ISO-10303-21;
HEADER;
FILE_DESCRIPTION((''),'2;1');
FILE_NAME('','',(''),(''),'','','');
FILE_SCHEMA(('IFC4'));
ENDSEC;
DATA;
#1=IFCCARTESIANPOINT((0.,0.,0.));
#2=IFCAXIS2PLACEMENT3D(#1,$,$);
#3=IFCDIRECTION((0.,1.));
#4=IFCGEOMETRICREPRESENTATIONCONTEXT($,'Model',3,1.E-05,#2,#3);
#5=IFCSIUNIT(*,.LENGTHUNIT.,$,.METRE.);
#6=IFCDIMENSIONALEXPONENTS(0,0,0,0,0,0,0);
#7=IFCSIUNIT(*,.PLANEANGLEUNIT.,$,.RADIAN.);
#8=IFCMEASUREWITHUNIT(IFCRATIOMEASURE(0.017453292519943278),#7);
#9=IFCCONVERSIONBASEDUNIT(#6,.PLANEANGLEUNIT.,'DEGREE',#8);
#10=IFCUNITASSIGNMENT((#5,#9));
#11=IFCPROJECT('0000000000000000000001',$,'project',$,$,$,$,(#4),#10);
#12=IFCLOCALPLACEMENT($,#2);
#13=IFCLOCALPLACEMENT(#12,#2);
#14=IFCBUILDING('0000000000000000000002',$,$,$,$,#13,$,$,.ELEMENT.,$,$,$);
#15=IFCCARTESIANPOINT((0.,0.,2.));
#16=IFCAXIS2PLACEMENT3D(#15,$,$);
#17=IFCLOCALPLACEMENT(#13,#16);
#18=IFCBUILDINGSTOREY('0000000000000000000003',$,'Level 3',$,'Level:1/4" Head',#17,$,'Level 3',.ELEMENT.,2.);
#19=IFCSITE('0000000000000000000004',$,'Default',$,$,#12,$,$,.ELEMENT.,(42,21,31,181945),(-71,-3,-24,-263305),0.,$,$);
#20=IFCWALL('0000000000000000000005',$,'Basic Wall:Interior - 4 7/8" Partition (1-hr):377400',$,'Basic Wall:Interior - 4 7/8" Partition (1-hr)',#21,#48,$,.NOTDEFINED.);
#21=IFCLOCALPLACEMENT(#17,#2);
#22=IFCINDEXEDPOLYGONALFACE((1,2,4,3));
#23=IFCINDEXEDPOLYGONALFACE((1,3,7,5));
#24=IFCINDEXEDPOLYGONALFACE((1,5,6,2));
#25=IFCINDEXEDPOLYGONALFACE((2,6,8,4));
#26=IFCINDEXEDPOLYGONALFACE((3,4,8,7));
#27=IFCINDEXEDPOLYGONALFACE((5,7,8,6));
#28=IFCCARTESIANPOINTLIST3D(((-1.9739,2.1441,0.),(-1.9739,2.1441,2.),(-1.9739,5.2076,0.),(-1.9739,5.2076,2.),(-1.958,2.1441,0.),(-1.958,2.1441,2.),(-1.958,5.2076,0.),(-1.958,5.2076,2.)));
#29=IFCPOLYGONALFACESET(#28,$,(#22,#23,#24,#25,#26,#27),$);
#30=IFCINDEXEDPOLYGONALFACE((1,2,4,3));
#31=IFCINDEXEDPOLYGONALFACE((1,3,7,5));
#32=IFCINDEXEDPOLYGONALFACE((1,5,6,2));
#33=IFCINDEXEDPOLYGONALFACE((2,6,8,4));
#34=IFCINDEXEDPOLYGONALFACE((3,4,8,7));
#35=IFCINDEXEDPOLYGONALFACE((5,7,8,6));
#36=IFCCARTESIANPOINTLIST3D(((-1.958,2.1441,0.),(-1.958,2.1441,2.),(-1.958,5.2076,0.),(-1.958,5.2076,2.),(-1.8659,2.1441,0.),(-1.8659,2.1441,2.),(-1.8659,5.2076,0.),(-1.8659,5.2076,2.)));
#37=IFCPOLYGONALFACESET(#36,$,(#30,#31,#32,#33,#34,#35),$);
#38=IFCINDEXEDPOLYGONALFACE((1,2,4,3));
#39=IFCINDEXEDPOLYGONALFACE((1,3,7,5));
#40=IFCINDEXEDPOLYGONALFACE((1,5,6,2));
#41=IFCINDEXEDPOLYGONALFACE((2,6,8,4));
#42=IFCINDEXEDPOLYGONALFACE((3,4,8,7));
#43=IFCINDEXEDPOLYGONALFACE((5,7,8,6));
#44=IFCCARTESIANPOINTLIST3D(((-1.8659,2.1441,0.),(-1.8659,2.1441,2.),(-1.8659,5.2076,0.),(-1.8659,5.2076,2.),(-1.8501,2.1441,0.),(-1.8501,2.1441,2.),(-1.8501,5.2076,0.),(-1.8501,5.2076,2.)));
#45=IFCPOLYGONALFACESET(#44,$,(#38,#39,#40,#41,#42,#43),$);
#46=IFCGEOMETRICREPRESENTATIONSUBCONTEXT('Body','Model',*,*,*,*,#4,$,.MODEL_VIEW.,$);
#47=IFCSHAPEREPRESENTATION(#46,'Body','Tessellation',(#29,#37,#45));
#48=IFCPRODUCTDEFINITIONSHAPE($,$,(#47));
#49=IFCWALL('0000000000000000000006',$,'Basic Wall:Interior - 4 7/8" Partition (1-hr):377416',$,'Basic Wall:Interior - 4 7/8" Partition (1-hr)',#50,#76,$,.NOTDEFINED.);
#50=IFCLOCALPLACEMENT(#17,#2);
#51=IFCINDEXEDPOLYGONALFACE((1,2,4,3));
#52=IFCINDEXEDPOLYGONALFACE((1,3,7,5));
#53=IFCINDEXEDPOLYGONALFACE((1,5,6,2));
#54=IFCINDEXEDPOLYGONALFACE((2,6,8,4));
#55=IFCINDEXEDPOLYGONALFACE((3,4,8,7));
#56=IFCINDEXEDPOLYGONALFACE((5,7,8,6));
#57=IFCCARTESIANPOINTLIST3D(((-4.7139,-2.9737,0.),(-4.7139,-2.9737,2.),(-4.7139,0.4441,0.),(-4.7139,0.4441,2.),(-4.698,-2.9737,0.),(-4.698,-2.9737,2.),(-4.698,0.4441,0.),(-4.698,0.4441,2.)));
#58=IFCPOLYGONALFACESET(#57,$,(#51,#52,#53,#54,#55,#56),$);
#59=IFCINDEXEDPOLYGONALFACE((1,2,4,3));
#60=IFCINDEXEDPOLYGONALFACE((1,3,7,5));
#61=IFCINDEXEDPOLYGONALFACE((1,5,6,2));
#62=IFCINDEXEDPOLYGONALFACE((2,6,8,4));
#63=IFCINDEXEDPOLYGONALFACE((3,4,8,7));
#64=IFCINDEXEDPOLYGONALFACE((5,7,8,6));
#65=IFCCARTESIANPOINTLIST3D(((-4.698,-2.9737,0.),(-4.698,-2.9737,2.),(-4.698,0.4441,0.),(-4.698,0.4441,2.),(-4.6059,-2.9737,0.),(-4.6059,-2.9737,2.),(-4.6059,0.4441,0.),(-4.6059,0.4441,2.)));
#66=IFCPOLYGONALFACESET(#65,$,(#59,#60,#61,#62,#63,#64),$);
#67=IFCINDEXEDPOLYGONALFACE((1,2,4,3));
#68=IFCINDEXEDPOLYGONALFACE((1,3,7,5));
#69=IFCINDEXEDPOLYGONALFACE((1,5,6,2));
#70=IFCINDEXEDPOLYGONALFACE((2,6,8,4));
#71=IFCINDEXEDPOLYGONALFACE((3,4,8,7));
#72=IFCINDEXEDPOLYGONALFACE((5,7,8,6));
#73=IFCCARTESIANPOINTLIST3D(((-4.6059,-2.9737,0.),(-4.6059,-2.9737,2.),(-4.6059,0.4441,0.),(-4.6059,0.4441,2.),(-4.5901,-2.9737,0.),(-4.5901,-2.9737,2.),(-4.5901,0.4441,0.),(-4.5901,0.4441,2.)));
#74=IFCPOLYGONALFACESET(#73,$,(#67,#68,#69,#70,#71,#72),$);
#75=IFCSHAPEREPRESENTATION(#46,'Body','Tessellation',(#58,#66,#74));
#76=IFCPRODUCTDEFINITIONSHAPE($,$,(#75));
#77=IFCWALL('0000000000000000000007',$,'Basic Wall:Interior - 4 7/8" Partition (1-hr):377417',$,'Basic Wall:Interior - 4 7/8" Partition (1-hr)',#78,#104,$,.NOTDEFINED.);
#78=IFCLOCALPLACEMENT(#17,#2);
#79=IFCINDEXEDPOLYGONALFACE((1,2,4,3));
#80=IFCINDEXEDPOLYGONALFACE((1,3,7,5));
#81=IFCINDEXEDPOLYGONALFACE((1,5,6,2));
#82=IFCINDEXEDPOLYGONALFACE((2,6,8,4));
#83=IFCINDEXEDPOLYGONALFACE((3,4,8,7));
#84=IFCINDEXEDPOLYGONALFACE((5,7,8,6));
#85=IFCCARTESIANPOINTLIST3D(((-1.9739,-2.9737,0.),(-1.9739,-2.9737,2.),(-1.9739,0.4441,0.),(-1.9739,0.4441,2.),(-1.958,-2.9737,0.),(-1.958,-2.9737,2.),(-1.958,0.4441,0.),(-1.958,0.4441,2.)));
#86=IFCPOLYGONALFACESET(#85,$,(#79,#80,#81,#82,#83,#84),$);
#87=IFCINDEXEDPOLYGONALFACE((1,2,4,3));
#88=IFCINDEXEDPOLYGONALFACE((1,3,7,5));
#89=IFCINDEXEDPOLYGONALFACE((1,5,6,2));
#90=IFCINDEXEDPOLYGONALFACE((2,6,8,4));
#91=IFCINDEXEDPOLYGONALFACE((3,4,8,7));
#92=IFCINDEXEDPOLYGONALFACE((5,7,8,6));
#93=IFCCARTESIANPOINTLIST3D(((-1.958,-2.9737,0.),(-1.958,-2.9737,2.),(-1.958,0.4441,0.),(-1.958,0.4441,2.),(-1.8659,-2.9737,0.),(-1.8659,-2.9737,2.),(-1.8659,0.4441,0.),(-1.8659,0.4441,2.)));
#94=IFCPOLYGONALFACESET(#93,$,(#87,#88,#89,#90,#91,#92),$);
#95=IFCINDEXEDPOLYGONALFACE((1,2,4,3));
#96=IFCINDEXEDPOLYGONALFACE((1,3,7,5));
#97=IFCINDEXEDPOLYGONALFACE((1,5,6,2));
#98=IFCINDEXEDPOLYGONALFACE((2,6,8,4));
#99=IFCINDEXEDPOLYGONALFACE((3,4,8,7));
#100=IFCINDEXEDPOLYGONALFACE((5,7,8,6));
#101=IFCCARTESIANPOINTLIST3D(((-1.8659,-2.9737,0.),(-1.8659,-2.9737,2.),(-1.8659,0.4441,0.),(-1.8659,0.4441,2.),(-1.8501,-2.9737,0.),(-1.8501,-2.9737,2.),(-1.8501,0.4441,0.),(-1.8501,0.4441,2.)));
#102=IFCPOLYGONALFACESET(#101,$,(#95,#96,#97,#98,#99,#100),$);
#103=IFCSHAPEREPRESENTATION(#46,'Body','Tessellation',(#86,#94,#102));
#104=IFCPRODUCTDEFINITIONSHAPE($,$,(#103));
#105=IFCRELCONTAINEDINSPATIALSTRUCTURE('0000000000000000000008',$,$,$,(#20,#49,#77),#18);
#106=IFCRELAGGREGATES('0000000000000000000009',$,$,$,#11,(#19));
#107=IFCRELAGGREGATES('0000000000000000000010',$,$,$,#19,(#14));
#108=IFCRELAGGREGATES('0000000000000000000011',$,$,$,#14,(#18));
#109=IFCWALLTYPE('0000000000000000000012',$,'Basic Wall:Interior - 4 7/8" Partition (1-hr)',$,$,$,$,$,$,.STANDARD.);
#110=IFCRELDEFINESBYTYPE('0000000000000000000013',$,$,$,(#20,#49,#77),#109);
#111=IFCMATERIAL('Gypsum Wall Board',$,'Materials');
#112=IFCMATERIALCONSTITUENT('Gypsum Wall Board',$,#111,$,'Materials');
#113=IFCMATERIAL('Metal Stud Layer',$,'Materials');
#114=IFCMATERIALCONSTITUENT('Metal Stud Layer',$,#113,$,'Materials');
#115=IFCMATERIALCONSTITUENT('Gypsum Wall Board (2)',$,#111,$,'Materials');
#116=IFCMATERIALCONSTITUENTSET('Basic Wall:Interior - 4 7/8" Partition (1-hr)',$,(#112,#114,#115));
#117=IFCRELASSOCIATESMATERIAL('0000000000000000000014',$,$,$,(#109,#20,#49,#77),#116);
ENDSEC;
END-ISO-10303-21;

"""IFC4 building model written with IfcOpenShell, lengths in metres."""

from ifc_helpers import new_model, entity, si_unit, converted_unit, direction, frame, origin, place, context, subcontext, project, spatial, indexed_curve, outline, extrude, material, constituent, constituent_set, type_object, element, save


model = new_model("IFC4")

# Units and contexts
model_context = context("Model", 3, precision=1e-05, world=origin(), true_north=direction((0.0, 1.0)))
body_context = subcontext(model_context, "Body", "Model", "MODEL_VIEW")
ifc_project = project(units=[si_unit("LENGTHUNIT", "METRE"), converted_unit("PLANEANGLEUNIT", "DEGREE", entity("IfcRatioMeasure", 0.017453292519943278), si_unit("PLANEANGLEUNIT", "RADIAN"), dimensions=[0, 0, 0, 0, 0, 0, 0])], contexts=[model_context])

# Site, building, storey
site_placement = place(None, origin())
site = spatial("IfcSite", under=ifc_project, at=site_placement, Name="Default", CompositionType="ELEMENT", RefLatitude=(42, 21, 31, 181945), RefLongitude=(-71, -3, -24, -263305), RefElevation=0.0)
building_placement = place(site_placement, origin())
building = spatial("IfcBuilding", under=site, at=building_placement, CompositionType="ELEMENT")
storey_placement = place(building_placement, frame((0.0, 0.0, 2.0)))
storey = spatial("IfcBuildingStorey", under=building, at=storey_placement, Name="Level 3", ObjectType="Level:1/4\" Head", LongName="Level 3", CompositionType="ELEMENT", Elevation=2.0)

# Walls
ifc_material_1 = material(Name="Gypsum Wall Board", Category="Materials")
ifc_constituent_1 = constituent(ifc_material_1, Name="Gypsum Wall Board", Category="Materials")
ifc_material_2 = material(Name="Metal Stud Layer", Category="Materials")
ifc_constituent_2 = constituent(ifc_material_2, Name="Metal Stud Layer", Category="Materials")
ifc_constituent_3 = constituent(ifc_material_1, Name="Gypsum Wall Board (2)", Category="Materials")
ifc_constituent_set = constituent_set(constituents=[ifc_constituent_1, ifc_constituent_2, ifc_constituent_3], Name="Basic Wall:Interior - 4 7/8\" Partition (1-hr)")
wall_type_1 = type_object("IfcWallType", Name="Basic Wall:Interior - 4 7/8\" Partition (1-hr)", PredefinedType="STANDARD", material=ifc_constituent_set)
wall_1_placement = place(storey_placement, frame((-1.912, 5.2076, 0.0), z_axis=(0.0, 0.0, 1.0), x_axis=(0.0, -1.0, 0.0)))
element("IfcWall", 1, at=wall_1_placement, inside=storey, type_object=wall_type_1, material=ifc_constituent_set, Name="Basic Wall:Interior - 4 7/8\" Partition (1-hr):377400", ObjectType="Basic Wall:Interior - 4 7/8\" Partition (1-hr)", PredefinedType="NOTDEFINED", context=body_context, shape_type="SweptSolid", body=[
    extrude(outline(indexed_curve([(-0.0079, -1.5318), (0.0079, -1.5318), (0.0079, 1.5318), (-0.0079, 1.5318), (-0.0079, -1.5318)], self_intersect=False)), frame((1.5318, -0.054, 0.0), z_axis=(0.0, 0.0, 1.0), x_axis=(0.0, 1.0, 0.0)), (0.0, 0.0, 1.0), 2.0),
    extrude(outline(indexed_curve([(-1.5318, -0.046), (1.5318, -0.046), (1.5318, 0.046), (-1.5318, 0.046), (-1.5318, -0.046)], self_intersect=False)), frame((1.5318, 0.0, 0.0)), (0.0, 0.0, 1.0), 2.0),
    extrude(outline(indexed_curve([(-0.0079, -1.5318), (0.0079, -1.5318), (0.0079, 1.5318), (-0.0079, 1.5318), (-0.0079, -1.5318)], self_intersect=False)), frame((1.5318, 0.054, 0.0), z_axis=(0.0, 0.0, 1.0), x_axis=(0.0, -1.0, 0.0)), (0.0, 0.0, 1.0), 2.0),
])
wall_2_placement = place(storey_placement, frame((-4.652, 0.4441, 0.0), z_axis=(0.0, 0.0, 1.0), x_axis=(0.0, -1.0, 0.0)))
element("IfcWall", 2, at=wall_2_placement, inside=storey, type_object=wall_type_1, material=ifc_constituent_set, Name="Basic Wall:Interior - 4 7/8\" Partition (1-hr):377416", ObjectType="Basic Wall:Interior - 4 7/8\" Partition (1-hr)", PredefinedType="NOTDEFINED", context=body_context, shape_type="SweptSolid", body=[
    extrude(outline(indexed_curve([(-0.0079, -1.7089), (0.0079, -1.7089), (0.0079, 1.7089), (-0.0079, 1.7089), (-0.0079, -1.7089)], self_intersect=False)), frame((1.7089, -0.054, 0.0), z_axis=(0.0, 0.0, 1.0), x_axis=(0.0, 1.0, 0.0)), (0.0, 0.0, 1.0), 2.0),
    extrude(outline(indexed_curve([(-1.7089, -0.046), (1.7089, -0.046), (1.7089, 0.046), (-1.7089, 0.046), (-1.7089, -0.046)], self_intersect=False)), frame((1.7089, 0.0, 0.0)), (0.0, 0.0, 1.0), 2.0),
    extrude(outline(indexed_curve([(-0.0079, -1.7089), (0.0079, -1.7089), (0.0079, 1.7089), (-0.0079, 1.7089), (-0.0079, -1.7089)], self_intersect=False)), frame((1.7089, 0.054, 0.0), z_axis=(0.0, 0.0, 1.0), x_axis=(0.0, -1.0, 0.0)), (0.0, 0.0, 1.0), 2.0),
])
wall_3_placement = place(storey_placement, frame((-1.912, 0.4441, 0.0), z_axis=(0.0, 0.0, 1.0), x_axis=(0.0, -1.0, 0.0)))
element("IfcWall", 3, at=wall_3_placement, inside=storey, type_object=wall_type_1, material=ifc_constituent_set, Name="Basic Wall:Interior - 4 7/8\" Partition (1-hr):377417", ObjectType="Basic Wall:Interior - 4 7/8\" Partition (1-hr)", PredefinedType="NOTDEFINED", context=body_context, shape_type="SweptSolid", body=[
    extrude(outline(indexed_curve([(-0.0079, -1.7089), (0.0079, -1.7089), (0.0079, 1.7089), (-0.0079, 1.7089), (-0.0079, -1.7089)], self_intersect=False)), frame((1.7089, -0.054, 0.0), z_axis=(0.0, 0.0, 1.0), x_axis=(0.0, 1.0, 0.0)), (0.0, 0.0, 1.0), 2.0),
    extrude(outline(indexed_curve([(-1.7089, -0.046), (1.7089, -0.046), (1.7089, 0.046), (-1.7089, 0.046), (-1.7089, -0.046)], self_intersect=False)), frame((1.7089, 0.0, 0.0)), (0.0, 0.0, 1.0), 2.0),
    extrude(outline(indexed_curve([(-0.0079, -1.7089), (0.0079, -1.7089), (0.0079, 1.7089), (-0.0079, 1.7089), (-0.0079, -1.7089)], self_intersect=False)), frame((1.7089, 0.054, 0.0), z_axis=(0.0, 0.0, 1.0), x_axis=(0.0, -1.0, 0.0)), (0.0, 0.0, 1.0), 2.0),
])

save(model, "model.ifc")
